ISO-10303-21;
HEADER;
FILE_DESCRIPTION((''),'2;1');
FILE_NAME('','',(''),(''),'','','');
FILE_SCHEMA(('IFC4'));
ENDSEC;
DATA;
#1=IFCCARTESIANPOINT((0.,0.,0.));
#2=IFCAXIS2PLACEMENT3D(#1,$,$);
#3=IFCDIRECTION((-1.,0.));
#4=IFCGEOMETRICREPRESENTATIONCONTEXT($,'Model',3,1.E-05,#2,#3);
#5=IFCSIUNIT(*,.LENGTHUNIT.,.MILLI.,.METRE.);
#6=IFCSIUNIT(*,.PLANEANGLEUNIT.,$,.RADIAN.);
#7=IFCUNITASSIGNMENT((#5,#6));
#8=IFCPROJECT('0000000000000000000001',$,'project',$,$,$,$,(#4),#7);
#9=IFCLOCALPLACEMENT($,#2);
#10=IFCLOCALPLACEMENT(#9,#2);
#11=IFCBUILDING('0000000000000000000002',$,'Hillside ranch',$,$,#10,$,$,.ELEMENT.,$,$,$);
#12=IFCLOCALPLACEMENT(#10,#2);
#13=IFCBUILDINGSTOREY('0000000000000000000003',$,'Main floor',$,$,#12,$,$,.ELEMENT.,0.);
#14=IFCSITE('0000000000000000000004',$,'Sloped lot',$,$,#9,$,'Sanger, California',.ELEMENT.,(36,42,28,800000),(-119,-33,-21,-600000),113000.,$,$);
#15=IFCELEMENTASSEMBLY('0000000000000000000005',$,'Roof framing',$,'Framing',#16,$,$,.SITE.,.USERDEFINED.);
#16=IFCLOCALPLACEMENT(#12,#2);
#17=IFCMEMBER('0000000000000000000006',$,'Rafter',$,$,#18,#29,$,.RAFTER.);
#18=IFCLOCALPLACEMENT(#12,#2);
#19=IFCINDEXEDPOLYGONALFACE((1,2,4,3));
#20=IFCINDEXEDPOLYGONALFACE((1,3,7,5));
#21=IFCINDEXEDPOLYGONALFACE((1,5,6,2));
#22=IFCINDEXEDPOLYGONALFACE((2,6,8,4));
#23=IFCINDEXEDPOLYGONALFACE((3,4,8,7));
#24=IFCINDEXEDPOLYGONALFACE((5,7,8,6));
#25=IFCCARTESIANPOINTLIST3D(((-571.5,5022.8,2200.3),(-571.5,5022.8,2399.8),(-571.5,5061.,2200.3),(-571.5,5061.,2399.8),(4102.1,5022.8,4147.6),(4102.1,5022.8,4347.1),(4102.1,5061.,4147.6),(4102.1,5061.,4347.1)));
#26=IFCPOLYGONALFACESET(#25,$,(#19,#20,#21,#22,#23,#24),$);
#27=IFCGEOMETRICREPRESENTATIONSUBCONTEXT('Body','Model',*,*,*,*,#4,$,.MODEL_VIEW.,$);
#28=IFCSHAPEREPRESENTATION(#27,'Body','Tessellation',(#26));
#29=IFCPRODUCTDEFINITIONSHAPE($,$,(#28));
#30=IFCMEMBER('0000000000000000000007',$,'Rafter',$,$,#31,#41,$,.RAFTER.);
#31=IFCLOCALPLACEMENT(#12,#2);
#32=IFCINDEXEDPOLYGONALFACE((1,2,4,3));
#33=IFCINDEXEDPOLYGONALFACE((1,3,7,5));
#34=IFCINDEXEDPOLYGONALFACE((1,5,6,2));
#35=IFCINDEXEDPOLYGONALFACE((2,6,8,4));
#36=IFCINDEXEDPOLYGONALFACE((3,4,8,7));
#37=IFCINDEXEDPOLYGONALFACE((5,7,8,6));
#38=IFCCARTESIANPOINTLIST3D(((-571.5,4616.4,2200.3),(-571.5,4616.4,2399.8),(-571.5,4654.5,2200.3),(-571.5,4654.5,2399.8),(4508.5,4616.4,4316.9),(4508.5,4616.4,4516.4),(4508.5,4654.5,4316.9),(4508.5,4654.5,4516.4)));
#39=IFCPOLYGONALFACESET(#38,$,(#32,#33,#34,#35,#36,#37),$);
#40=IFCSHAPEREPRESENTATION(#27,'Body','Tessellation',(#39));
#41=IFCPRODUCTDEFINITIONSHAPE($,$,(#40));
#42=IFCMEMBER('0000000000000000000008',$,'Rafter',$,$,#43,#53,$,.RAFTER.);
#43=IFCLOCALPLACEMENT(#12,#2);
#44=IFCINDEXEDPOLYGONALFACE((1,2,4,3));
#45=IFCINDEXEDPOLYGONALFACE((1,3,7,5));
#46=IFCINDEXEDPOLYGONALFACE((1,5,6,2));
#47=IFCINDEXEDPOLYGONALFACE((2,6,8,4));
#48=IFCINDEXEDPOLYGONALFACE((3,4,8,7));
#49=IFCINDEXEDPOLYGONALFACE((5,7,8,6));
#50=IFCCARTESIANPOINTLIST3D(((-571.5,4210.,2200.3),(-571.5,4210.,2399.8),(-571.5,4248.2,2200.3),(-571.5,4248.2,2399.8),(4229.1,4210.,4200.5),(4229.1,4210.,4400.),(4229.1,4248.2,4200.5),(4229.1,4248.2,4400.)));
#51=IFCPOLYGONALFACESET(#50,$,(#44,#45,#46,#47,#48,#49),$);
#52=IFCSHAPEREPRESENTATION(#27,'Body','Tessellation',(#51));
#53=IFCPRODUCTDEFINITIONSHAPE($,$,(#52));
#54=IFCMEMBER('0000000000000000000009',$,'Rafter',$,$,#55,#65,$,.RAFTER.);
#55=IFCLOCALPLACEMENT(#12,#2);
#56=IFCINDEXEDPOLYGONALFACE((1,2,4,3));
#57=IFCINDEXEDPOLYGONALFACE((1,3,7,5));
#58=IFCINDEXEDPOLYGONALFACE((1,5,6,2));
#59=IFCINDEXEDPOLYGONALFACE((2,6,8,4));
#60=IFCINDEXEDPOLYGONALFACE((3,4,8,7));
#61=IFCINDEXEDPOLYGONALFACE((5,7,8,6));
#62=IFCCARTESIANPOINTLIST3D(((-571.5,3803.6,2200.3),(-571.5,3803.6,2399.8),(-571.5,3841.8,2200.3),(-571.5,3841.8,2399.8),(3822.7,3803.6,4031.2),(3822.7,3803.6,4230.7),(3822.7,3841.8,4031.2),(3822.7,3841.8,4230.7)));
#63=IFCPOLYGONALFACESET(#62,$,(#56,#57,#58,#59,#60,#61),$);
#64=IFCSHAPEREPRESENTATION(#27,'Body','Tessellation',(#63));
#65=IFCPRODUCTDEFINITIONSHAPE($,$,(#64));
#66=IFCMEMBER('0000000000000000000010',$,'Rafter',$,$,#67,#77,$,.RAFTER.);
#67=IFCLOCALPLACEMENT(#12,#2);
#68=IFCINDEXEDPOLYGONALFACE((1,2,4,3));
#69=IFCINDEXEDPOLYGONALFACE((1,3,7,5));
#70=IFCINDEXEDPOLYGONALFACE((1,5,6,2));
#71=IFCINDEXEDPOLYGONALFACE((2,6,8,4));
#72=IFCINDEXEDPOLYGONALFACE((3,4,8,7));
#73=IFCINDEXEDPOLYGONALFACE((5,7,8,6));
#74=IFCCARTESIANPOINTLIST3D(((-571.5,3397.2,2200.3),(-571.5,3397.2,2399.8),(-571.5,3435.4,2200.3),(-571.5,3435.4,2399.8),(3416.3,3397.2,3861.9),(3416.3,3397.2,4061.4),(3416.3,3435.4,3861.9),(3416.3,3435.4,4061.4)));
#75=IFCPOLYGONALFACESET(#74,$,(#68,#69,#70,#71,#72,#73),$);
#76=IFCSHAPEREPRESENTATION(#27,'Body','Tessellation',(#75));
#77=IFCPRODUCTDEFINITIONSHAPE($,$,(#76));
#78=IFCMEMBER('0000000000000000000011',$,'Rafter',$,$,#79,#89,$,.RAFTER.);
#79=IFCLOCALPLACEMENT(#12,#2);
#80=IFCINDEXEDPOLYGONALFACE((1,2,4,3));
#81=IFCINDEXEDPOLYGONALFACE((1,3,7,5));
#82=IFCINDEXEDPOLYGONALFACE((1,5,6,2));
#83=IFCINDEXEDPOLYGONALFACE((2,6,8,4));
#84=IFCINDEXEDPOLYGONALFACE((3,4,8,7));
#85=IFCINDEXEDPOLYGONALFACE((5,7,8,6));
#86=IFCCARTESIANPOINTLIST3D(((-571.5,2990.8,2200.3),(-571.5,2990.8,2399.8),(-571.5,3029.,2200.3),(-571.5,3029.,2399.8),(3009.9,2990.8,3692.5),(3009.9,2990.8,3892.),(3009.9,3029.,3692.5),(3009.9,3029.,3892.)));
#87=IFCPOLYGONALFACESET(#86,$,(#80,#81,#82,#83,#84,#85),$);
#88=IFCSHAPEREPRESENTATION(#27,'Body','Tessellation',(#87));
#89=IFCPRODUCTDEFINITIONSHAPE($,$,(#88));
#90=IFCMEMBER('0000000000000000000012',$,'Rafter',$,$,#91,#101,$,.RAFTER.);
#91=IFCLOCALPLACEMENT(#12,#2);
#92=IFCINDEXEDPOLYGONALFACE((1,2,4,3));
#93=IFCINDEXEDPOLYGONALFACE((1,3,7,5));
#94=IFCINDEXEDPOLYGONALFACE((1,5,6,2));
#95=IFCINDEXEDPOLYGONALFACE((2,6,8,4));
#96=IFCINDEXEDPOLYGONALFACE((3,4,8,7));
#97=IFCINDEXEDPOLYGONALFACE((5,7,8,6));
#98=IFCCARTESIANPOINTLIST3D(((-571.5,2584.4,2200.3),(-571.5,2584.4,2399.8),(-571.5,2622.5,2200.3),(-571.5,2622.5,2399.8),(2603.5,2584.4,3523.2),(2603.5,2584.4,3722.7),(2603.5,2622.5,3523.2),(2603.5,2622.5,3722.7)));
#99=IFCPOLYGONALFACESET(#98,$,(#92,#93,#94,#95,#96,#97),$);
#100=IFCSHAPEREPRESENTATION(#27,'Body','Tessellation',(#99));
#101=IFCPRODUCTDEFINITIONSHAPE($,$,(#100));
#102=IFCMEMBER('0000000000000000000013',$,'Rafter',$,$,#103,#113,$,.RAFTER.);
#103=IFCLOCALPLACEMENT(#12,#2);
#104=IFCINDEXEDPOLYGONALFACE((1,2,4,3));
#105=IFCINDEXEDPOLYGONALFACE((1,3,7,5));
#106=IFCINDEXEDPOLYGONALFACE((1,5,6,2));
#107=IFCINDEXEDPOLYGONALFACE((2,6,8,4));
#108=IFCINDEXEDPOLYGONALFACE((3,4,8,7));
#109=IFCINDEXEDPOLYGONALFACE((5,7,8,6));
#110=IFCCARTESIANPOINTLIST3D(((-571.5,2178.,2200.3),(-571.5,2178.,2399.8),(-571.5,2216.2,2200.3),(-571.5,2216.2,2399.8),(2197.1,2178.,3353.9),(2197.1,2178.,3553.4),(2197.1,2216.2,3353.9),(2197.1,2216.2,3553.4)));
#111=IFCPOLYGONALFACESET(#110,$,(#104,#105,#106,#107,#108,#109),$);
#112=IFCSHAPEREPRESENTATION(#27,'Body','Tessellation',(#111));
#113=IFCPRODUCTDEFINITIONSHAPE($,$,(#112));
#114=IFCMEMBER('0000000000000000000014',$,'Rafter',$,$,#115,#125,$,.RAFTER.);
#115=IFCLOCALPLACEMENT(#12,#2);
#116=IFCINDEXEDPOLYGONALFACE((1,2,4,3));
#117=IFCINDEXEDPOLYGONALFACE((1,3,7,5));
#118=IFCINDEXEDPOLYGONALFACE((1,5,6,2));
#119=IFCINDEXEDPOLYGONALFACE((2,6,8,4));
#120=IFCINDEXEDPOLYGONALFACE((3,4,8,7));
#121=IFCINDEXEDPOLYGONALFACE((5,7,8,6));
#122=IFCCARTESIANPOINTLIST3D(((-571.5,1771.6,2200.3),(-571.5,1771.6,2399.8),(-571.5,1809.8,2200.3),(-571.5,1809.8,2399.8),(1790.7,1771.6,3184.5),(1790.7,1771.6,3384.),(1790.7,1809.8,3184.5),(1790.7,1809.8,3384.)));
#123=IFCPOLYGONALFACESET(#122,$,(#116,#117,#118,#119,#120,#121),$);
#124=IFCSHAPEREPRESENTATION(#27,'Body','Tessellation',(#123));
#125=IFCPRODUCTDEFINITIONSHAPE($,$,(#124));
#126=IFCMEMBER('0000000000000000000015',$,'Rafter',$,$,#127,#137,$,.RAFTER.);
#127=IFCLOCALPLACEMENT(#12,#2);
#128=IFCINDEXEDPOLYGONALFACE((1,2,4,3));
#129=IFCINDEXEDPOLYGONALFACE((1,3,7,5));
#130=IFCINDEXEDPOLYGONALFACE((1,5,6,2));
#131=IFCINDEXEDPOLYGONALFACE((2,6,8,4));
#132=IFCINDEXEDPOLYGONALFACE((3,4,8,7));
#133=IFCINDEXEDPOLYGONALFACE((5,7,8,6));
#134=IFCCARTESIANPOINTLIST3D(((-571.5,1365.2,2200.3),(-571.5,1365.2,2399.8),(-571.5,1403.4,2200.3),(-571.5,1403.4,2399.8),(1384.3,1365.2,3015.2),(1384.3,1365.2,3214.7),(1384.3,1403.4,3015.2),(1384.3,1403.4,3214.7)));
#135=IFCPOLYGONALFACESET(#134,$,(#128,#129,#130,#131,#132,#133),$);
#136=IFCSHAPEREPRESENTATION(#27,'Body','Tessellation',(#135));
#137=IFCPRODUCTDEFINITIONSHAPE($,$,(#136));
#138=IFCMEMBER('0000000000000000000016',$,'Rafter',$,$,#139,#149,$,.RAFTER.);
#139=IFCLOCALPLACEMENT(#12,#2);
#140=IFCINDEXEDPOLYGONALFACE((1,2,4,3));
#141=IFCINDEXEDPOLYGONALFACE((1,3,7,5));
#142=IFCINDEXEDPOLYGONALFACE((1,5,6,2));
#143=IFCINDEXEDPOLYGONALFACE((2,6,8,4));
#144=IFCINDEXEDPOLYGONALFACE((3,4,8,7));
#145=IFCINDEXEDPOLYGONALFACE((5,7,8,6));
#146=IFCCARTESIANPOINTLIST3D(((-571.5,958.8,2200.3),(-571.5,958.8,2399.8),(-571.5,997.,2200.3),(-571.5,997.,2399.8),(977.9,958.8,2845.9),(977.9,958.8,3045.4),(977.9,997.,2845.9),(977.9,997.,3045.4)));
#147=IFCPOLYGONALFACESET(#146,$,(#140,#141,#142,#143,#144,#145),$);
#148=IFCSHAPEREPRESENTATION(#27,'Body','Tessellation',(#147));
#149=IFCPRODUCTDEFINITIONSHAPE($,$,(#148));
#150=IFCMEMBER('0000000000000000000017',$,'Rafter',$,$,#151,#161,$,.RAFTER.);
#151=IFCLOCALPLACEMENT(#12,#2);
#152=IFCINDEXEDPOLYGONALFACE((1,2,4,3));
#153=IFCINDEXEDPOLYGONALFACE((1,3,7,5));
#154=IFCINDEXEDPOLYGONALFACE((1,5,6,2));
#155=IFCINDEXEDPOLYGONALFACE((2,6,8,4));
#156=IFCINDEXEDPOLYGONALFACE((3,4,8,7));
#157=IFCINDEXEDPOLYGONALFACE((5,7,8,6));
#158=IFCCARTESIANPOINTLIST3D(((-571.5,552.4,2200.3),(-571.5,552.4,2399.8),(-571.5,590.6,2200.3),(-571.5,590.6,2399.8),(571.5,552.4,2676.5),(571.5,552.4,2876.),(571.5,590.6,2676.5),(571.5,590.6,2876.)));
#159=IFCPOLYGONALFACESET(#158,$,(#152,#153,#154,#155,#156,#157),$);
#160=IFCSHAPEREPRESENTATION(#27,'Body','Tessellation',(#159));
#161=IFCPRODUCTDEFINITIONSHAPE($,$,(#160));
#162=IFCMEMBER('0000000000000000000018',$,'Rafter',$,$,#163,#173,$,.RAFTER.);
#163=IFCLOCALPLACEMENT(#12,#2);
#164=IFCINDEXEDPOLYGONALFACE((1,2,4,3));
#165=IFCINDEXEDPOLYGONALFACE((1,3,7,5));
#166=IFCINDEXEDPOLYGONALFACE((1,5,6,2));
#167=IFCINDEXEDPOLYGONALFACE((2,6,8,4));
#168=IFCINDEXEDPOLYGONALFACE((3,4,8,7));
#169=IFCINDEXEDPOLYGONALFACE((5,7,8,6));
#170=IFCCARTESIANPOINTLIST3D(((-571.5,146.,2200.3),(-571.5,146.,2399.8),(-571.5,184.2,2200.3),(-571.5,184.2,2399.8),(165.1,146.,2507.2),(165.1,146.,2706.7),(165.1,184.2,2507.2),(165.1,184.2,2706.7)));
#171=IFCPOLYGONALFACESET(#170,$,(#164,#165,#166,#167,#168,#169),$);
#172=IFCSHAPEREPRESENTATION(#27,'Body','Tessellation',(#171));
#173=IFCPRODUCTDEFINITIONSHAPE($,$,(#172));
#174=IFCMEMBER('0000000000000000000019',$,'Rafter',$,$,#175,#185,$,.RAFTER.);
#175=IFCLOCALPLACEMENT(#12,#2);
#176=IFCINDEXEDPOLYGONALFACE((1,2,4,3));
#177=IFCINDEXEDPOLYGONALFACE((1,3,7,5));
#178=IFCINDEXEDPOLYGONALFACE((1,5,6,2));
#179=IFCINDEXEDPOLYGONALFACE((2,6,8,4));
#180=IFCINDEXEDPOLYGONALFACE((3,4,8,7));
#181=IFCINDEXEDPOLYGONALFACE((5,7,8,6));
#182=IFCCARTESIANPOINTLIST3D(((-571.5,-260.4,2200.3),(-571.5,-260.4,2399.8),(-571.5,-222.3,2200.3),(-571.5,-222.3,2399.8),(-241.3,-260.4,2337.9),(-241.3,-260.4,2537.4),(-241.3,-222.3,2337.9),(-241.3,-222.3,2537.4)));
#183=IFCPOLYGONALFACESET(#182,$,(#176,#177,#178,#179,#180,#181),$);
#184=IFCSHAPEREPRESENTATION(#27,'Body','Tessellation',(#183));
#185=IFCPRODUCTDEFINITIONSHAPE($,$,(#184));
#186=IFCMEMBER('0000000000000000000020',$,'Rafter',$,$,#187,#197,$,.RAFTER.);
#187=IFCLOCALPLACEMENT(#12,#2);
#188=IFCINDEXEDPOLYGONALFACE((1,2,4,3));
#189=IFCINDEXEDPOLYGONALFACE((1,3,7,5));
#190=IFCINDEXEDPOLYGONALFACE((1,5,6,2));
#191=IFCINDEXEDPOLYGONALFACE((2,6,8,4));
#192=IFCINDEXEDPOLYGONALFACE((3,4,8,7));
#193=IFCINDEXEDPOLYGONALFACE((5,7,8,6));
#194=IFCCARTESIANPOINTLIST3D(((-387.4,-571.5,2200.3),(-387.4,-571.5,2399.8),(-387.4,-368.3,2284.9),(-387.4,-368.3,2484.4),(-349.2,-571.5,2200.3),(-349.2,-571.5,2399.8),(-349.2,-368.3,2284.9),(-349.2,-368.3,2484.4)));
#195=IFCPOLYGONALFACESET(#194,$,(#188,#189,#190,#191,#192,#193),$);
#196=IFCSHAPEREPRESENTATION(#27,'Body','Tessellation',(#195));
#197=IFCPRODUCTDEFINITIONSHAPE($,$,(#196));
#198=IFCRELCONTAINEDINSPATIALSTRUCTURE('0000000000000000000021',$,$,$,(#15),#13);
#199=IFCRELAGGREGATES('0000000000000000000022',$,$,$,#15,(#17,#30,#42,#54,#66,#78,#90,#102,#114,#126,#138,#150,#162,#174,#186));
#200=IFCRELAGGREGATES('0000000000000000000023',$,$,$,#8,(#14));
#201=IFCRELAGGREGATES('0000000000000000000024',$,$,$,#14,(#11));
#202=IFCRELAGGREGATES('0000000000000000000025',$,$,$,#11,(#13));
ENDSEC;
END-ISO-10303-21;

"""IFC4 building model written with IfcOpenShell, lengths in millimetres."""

from ifc_helpers import new_model, si_unit, direction, frame, origin, origin_with_axes, place, context, subcontext, project, spatial, polyline, outline, extrude, element, aggregate, save


model = new_model("IFC4")

# Units and contexts
model_context = context("Model", 3, precision=1e-05, world=origin(), true_north=direction((-1.0, 0.0)))
body_context = subcontext(model_context, "Body", "Model", "MODEL_VIEW")
ifc_project = project(units=[si_unit("LENGTHUNIT", "METRE", prefix="MILLI"), si_unit("PLANEANGLEUNIT", "RADIAN")], contexts=[model_context])

# Site, building, storey
site_placement = place(None, origin())
site = spatial("IfcSite", under=ifc_project, at=site_placement, Name="Sloped lot", LongName="Sanger, California", CompositionType="ELEMENT", RefLatitude=(36, 42, 28, 800000), RefLongitude=(-119, -33, -21, -600000), RefElevation=113000.0)
building_placement = place(site_placement, origin())
building = spatial("IfcBuilding", under=site, at=building_placement, Name="Hillside ranch", CompositionType="ELEMENT")
storey_placement = place(building_placement, origin())
storey = spatial("IfcBuildingStorey", under=building, at=storey_placement, Name="Main floor", CompositionType="ELEMENT", Elevation=0.0)

# Element assembly, members
assembly_placement = place(storey_placement, origin_with_axes())
assembly = element("IfcElementAssembly", 1, at=assembly_placement, inside=storey, Name="Roof framing", ObjectType="Framing", AssemblyPlace="SITE", PredefinedType="USERDEFINED")
member_1_placement = place(storey_placement, origin_with_axes())
member_1 = element("IfcMember", 2, at=member_1_placement, Name="Rafter", PredefinedType="RAFTER", context=body_context, shape_type="SweptSolid", body=[
    extrude(outline(polyline([(0.0, 0.0), (38.1, 0.0), (38.1, 199.5), (0.0, 199.5), (0.0, 0.0)])), frame((-571.5, 5022.9, 2200.3), z_axis=(1.0, 0.0, 0.0), x_axis=(0.0, 1.0, 0.0)), (0.0, 0.384615, 0.923077), 5063.1),
])
member_2_placement = place(storey_placement, origin_with_axes())
member_2 = element("IfcMember", 3, at=member_2_placement, Name="Rafter", PredefinedType="RAFTER", context=body_context, shape_type="SweptSolid", body=[
    extrude(outline(polyline([(0.0, 0.0), (38.1, 0.0), (38.1, 199.5), (0.0, 199.5), (0.0, 0.0)])), frame((-571.5, 4616.4, 2200.3), z_axis=(1.0, 0.0, 0.0), x_axis=(0.0, 1.0, 0.0)), (0.0, 0.384615, 0.923077), 5503.3),
])
member_3_placement = place(storey_placement, origin_with_axes())
member_3 = element("IfcMember", 4, at=member_3_placement, Name="Rafter", PredefinedType="RAFTER", context=body_context, shape_type="SweptSolid", body=[
    extrude(outline(polyline([(0.0, 0.0), (38.1, 0.0), (38.1, 199.5), (0.0, 199.5), (0.0, 0.0)])), frame((-571.5, 4210.1, 2200.3), z_axis=(1.0, 0.0, 0.0), x_axis=(0.0, 1.0, 0.0)), (0.0, 0.384615, 0.923077), 5200.6),
])
member_4_placement = place(storey_placement, origin_with_axes())
member_4 = element("IfcMember", 5, at=member_4_placement, Name="Rafter", PredefinedType="RAFTER", context=body_context, shape_type="SweptSolid", body=[
    extrude(outline(polyline([(0.0, 0.0), (38.1, 0.0), (38.1, 199.5), (0.0, 199.5), (0.0, 0.0)])), frame((-571.5, 3803.7, 2200.3), z_axis=(1.0, 0.0, 0.0), x_axis=(0.0, 1.0, 0.0)), (0.0, 0.384615, 0.923077), 4760.4),
])
member_5_placement = place(storey_placement, origin_with_axes())
member_5 = element("IfcMember", 6, at=member_5_placement, Name="Rafter", PredefinedType="RAFTER", context=body_context, shape_type="SweptSolid", body=[
    extrude(outline(polyline([(0.0, 0.0), (38.1, 0.0), (38.1, 199.5), (0.0, 199.5), (0.0, 0.0)])), frame((-571.5, 3397.2, 2200.3), z_axis=(1.0, 0.0, 0.0), x_axis=(0.0, 1.0, 0.0)), (0.0, 0.384615, 0.923077), 4320.1),
])
member_6_placement = place(storey_placement, origin_with_axes())
member_6 = element("IfcMember", 7, at=member_6_placement, Name="Rafter", PredefinedType="RAFTER", context=body_context, shape_type="SweptSolid", body=[
    extrude(outline(polyline([(0.0, 0.0), (38.1, 0.0), (38.1, 199.5), (0.0, 199.5), (0.0, 0.0)])), frame((-571.5, 2990.8, 2200.3), z_axis=(1.0, 0.0, 0.0), x_axis=(0.0, 1.0, 0.0)), (0.0, 0.384615, 0.923077), 3879.8),
])
member_7_placement = place(storey_placement, origin_with_axes())
member_7 = element("IfcMember", 8, at=member_7_placement, Name="Rafter", PredefinedType="RAFTER", context=body_context, shape_type="SweptSolid", body=[
    extrude(outline(polyline([(0.0, 0.0), (38.1, 0.0), (38.1, 199.5), (0.0, 199.5), (0.0, 0.0)])), frame((-571.5, 2584.4, 2200.3), z_axis=(1.0, 0.0, 0.0), x_axis=(0.0, 1.0, 0.0)), (0.0, 0.384615, 0.923077), 3439.6),
])
member_8_placement = place(storey_placement, origin_with_axes())
member_8 = element("IfcMember", 9, at=member_8_placement, Name="Rafter", PredefinedType="RAFTER", context=body_context, shape_type="SweptSolid", body=[
    extrude(outline(polyline([(0.0, 0.0), (38.1, 0.0), (38.1, 199.5), (0.0, 199.5), (0.0, 0.0)])), frame((-571.5, 2178.1, 2200.3), z_axis=(1.0, 0.0, 0.0), x_axis=(0.0, 1.0, 0.0)), (0.0, 0.384615, 0.923077), 2999.3),
])
member_9_placement = place(storey_placement, origin_with_axes())
member_9 = element("IfcMember", 10, at=member_9_placement, Name="Rafter", PredefinedType="RAFTER", context=body_context, shape_type="SweptSolid", body=[
    extrude(outline(polyline([(0.0, 0.0), (38.1, 0.0), (38.1, 199.5), (0.0, 199.5), (0.0, 0.0)])), frame((-571.5, 1771.7, 2200.3), z_axis=(1.0, 0.0, 0.0), x_axis=(0.0, 1.0, 0.0)), (0.0, 0.384615, 0.923077), 2559.1),
])
member_10_placement = place(storey_placement, origin_with_axes())
member_10 = element("IfcMember", 11, at=member_10_placement, Name="Rafter", PredefinedType="RAFTER", context=body_context, shape_type="SweptSolid", body=[
    extrude(outline(polyline([(0.0, 0.0), (38.1, 0.0), (38.1, 199.5), (0.0, 199.5), (0.0, 0.0)])), frame((-571.5, 1365.2, 2200.3), z_axis=(1.0, 0.0, 0.0), x_axis=(0.0, 1.0, 0.0)), (0.0, 0.384615, 0.923077), 2118.8),
])
member_11_placement = place(storey_placement, origin_with_axes())
member_11 = element("IfcMember", 12, at=member_11_placement, Name="Rafter", PredefinedType="RAFTER", context=body_context, shape_type="SweptSolid", body=[
    extrude(outline(polyline([(0.0, 0.0), (38.1, 0.0), (38.1, 199.5), (0.0, 199.5), (0.0, 0.0)])), frame((-571.5, 958.9, 2200.3), z_axis=(1.0, 0.0, 0.0), x_axis=(0.0, 1.0, 0.0)), (0.0, 0.384615, 0.923077), 1678.5),
])
member_12_placement = place(storey_placement, origin_with_axes())
member_12 = element("IfcMember", 13, at=member_12_placement, Name="Rafter", PredefinedType="RAFTER", context=body_context, shape_type="SweptSolid", body=[
    extrude(outline(polyline([(0.0, 0.0), (38.1, 0.0), (38.1, 199.5), (0.0, 199.5), (0.0, 0.0)])), frame((-571.5, 552.5, 2200.3), z_axis=(1.0, 0.0, 0.0), x_axis=(0.0, 1.0, 0.0)), (0.0, 0.384615, 0.923077), 1238.2),
])
member_13_placement = place(storey_placement, origin_with_axes())
member_13 = element("IfcMember", 14, at=member_13_placement, Name="Rafter", PredefinedType="RAFTER", context=body_context, shape_type="SweptSolid", body=[
    extrude(outline(polyline([(0.0, 0.0), (38.1, 0.0), (38.1, 199.5), (0.0, 199.5), (0.0, 0.0)])), frame((-571.5, 146.1, 2200.3), z_axis=(1.0, 0.0, 0.0), x_axis=(0.0, 1.0, 0.0)), (0.0, 0.384615, 0.923077), 798.0),
])
member_14_placement = place(storey_placement, origin_with_axes())
member_14 = element("IfcMember", 15, at=member_14_placement, Name="Rafter", PredefinedType="RAFTER", context=body_context, shape_type="SweptSolid", body=[
    extrude(outline(polyline([(0.0, 0.0), (38.1, 0.0), (38.1, 199.5), (0.0, 199.5), (0.0, 0.0)])), frame((-571.5, -260.4, 2200.3), z_axis=(1.0, 0.0, 0.0), x_axis=(0.0, 1.0, 0.0)), (0.0, 0.384615, 0.923077), 357.7),
])
member_15_placement = place(storey_placement, origin_with_axes())
member_15 = element("IfcMember", 16, at=member_15_placement, Name="Rafter", PredefinedType="RAFTER", context=body_context, shape_type="SweptSolid", body=[
    extrude(outline(polyline([(0.0, 0.0), (38.1, 0.0), (38.1, 199.5), (0.0, 199.5), (0.0, 0.0)])), frame((-349.2, -571.5, 2200.3), z_axis=(0.0, 1.0, 0.0), x_axis=(-1.0, 0.0, 0.0)), (0.0, 0.384615, 0.923077), 220.1),
])
aggregate(assembly, [member_1, member_2, member_3, member_4, member_5, member_6, member_7, member_8, member_9, member_10, member_11, member_12, member_13, member_14, member_15])

save(model, "model.ifc")
